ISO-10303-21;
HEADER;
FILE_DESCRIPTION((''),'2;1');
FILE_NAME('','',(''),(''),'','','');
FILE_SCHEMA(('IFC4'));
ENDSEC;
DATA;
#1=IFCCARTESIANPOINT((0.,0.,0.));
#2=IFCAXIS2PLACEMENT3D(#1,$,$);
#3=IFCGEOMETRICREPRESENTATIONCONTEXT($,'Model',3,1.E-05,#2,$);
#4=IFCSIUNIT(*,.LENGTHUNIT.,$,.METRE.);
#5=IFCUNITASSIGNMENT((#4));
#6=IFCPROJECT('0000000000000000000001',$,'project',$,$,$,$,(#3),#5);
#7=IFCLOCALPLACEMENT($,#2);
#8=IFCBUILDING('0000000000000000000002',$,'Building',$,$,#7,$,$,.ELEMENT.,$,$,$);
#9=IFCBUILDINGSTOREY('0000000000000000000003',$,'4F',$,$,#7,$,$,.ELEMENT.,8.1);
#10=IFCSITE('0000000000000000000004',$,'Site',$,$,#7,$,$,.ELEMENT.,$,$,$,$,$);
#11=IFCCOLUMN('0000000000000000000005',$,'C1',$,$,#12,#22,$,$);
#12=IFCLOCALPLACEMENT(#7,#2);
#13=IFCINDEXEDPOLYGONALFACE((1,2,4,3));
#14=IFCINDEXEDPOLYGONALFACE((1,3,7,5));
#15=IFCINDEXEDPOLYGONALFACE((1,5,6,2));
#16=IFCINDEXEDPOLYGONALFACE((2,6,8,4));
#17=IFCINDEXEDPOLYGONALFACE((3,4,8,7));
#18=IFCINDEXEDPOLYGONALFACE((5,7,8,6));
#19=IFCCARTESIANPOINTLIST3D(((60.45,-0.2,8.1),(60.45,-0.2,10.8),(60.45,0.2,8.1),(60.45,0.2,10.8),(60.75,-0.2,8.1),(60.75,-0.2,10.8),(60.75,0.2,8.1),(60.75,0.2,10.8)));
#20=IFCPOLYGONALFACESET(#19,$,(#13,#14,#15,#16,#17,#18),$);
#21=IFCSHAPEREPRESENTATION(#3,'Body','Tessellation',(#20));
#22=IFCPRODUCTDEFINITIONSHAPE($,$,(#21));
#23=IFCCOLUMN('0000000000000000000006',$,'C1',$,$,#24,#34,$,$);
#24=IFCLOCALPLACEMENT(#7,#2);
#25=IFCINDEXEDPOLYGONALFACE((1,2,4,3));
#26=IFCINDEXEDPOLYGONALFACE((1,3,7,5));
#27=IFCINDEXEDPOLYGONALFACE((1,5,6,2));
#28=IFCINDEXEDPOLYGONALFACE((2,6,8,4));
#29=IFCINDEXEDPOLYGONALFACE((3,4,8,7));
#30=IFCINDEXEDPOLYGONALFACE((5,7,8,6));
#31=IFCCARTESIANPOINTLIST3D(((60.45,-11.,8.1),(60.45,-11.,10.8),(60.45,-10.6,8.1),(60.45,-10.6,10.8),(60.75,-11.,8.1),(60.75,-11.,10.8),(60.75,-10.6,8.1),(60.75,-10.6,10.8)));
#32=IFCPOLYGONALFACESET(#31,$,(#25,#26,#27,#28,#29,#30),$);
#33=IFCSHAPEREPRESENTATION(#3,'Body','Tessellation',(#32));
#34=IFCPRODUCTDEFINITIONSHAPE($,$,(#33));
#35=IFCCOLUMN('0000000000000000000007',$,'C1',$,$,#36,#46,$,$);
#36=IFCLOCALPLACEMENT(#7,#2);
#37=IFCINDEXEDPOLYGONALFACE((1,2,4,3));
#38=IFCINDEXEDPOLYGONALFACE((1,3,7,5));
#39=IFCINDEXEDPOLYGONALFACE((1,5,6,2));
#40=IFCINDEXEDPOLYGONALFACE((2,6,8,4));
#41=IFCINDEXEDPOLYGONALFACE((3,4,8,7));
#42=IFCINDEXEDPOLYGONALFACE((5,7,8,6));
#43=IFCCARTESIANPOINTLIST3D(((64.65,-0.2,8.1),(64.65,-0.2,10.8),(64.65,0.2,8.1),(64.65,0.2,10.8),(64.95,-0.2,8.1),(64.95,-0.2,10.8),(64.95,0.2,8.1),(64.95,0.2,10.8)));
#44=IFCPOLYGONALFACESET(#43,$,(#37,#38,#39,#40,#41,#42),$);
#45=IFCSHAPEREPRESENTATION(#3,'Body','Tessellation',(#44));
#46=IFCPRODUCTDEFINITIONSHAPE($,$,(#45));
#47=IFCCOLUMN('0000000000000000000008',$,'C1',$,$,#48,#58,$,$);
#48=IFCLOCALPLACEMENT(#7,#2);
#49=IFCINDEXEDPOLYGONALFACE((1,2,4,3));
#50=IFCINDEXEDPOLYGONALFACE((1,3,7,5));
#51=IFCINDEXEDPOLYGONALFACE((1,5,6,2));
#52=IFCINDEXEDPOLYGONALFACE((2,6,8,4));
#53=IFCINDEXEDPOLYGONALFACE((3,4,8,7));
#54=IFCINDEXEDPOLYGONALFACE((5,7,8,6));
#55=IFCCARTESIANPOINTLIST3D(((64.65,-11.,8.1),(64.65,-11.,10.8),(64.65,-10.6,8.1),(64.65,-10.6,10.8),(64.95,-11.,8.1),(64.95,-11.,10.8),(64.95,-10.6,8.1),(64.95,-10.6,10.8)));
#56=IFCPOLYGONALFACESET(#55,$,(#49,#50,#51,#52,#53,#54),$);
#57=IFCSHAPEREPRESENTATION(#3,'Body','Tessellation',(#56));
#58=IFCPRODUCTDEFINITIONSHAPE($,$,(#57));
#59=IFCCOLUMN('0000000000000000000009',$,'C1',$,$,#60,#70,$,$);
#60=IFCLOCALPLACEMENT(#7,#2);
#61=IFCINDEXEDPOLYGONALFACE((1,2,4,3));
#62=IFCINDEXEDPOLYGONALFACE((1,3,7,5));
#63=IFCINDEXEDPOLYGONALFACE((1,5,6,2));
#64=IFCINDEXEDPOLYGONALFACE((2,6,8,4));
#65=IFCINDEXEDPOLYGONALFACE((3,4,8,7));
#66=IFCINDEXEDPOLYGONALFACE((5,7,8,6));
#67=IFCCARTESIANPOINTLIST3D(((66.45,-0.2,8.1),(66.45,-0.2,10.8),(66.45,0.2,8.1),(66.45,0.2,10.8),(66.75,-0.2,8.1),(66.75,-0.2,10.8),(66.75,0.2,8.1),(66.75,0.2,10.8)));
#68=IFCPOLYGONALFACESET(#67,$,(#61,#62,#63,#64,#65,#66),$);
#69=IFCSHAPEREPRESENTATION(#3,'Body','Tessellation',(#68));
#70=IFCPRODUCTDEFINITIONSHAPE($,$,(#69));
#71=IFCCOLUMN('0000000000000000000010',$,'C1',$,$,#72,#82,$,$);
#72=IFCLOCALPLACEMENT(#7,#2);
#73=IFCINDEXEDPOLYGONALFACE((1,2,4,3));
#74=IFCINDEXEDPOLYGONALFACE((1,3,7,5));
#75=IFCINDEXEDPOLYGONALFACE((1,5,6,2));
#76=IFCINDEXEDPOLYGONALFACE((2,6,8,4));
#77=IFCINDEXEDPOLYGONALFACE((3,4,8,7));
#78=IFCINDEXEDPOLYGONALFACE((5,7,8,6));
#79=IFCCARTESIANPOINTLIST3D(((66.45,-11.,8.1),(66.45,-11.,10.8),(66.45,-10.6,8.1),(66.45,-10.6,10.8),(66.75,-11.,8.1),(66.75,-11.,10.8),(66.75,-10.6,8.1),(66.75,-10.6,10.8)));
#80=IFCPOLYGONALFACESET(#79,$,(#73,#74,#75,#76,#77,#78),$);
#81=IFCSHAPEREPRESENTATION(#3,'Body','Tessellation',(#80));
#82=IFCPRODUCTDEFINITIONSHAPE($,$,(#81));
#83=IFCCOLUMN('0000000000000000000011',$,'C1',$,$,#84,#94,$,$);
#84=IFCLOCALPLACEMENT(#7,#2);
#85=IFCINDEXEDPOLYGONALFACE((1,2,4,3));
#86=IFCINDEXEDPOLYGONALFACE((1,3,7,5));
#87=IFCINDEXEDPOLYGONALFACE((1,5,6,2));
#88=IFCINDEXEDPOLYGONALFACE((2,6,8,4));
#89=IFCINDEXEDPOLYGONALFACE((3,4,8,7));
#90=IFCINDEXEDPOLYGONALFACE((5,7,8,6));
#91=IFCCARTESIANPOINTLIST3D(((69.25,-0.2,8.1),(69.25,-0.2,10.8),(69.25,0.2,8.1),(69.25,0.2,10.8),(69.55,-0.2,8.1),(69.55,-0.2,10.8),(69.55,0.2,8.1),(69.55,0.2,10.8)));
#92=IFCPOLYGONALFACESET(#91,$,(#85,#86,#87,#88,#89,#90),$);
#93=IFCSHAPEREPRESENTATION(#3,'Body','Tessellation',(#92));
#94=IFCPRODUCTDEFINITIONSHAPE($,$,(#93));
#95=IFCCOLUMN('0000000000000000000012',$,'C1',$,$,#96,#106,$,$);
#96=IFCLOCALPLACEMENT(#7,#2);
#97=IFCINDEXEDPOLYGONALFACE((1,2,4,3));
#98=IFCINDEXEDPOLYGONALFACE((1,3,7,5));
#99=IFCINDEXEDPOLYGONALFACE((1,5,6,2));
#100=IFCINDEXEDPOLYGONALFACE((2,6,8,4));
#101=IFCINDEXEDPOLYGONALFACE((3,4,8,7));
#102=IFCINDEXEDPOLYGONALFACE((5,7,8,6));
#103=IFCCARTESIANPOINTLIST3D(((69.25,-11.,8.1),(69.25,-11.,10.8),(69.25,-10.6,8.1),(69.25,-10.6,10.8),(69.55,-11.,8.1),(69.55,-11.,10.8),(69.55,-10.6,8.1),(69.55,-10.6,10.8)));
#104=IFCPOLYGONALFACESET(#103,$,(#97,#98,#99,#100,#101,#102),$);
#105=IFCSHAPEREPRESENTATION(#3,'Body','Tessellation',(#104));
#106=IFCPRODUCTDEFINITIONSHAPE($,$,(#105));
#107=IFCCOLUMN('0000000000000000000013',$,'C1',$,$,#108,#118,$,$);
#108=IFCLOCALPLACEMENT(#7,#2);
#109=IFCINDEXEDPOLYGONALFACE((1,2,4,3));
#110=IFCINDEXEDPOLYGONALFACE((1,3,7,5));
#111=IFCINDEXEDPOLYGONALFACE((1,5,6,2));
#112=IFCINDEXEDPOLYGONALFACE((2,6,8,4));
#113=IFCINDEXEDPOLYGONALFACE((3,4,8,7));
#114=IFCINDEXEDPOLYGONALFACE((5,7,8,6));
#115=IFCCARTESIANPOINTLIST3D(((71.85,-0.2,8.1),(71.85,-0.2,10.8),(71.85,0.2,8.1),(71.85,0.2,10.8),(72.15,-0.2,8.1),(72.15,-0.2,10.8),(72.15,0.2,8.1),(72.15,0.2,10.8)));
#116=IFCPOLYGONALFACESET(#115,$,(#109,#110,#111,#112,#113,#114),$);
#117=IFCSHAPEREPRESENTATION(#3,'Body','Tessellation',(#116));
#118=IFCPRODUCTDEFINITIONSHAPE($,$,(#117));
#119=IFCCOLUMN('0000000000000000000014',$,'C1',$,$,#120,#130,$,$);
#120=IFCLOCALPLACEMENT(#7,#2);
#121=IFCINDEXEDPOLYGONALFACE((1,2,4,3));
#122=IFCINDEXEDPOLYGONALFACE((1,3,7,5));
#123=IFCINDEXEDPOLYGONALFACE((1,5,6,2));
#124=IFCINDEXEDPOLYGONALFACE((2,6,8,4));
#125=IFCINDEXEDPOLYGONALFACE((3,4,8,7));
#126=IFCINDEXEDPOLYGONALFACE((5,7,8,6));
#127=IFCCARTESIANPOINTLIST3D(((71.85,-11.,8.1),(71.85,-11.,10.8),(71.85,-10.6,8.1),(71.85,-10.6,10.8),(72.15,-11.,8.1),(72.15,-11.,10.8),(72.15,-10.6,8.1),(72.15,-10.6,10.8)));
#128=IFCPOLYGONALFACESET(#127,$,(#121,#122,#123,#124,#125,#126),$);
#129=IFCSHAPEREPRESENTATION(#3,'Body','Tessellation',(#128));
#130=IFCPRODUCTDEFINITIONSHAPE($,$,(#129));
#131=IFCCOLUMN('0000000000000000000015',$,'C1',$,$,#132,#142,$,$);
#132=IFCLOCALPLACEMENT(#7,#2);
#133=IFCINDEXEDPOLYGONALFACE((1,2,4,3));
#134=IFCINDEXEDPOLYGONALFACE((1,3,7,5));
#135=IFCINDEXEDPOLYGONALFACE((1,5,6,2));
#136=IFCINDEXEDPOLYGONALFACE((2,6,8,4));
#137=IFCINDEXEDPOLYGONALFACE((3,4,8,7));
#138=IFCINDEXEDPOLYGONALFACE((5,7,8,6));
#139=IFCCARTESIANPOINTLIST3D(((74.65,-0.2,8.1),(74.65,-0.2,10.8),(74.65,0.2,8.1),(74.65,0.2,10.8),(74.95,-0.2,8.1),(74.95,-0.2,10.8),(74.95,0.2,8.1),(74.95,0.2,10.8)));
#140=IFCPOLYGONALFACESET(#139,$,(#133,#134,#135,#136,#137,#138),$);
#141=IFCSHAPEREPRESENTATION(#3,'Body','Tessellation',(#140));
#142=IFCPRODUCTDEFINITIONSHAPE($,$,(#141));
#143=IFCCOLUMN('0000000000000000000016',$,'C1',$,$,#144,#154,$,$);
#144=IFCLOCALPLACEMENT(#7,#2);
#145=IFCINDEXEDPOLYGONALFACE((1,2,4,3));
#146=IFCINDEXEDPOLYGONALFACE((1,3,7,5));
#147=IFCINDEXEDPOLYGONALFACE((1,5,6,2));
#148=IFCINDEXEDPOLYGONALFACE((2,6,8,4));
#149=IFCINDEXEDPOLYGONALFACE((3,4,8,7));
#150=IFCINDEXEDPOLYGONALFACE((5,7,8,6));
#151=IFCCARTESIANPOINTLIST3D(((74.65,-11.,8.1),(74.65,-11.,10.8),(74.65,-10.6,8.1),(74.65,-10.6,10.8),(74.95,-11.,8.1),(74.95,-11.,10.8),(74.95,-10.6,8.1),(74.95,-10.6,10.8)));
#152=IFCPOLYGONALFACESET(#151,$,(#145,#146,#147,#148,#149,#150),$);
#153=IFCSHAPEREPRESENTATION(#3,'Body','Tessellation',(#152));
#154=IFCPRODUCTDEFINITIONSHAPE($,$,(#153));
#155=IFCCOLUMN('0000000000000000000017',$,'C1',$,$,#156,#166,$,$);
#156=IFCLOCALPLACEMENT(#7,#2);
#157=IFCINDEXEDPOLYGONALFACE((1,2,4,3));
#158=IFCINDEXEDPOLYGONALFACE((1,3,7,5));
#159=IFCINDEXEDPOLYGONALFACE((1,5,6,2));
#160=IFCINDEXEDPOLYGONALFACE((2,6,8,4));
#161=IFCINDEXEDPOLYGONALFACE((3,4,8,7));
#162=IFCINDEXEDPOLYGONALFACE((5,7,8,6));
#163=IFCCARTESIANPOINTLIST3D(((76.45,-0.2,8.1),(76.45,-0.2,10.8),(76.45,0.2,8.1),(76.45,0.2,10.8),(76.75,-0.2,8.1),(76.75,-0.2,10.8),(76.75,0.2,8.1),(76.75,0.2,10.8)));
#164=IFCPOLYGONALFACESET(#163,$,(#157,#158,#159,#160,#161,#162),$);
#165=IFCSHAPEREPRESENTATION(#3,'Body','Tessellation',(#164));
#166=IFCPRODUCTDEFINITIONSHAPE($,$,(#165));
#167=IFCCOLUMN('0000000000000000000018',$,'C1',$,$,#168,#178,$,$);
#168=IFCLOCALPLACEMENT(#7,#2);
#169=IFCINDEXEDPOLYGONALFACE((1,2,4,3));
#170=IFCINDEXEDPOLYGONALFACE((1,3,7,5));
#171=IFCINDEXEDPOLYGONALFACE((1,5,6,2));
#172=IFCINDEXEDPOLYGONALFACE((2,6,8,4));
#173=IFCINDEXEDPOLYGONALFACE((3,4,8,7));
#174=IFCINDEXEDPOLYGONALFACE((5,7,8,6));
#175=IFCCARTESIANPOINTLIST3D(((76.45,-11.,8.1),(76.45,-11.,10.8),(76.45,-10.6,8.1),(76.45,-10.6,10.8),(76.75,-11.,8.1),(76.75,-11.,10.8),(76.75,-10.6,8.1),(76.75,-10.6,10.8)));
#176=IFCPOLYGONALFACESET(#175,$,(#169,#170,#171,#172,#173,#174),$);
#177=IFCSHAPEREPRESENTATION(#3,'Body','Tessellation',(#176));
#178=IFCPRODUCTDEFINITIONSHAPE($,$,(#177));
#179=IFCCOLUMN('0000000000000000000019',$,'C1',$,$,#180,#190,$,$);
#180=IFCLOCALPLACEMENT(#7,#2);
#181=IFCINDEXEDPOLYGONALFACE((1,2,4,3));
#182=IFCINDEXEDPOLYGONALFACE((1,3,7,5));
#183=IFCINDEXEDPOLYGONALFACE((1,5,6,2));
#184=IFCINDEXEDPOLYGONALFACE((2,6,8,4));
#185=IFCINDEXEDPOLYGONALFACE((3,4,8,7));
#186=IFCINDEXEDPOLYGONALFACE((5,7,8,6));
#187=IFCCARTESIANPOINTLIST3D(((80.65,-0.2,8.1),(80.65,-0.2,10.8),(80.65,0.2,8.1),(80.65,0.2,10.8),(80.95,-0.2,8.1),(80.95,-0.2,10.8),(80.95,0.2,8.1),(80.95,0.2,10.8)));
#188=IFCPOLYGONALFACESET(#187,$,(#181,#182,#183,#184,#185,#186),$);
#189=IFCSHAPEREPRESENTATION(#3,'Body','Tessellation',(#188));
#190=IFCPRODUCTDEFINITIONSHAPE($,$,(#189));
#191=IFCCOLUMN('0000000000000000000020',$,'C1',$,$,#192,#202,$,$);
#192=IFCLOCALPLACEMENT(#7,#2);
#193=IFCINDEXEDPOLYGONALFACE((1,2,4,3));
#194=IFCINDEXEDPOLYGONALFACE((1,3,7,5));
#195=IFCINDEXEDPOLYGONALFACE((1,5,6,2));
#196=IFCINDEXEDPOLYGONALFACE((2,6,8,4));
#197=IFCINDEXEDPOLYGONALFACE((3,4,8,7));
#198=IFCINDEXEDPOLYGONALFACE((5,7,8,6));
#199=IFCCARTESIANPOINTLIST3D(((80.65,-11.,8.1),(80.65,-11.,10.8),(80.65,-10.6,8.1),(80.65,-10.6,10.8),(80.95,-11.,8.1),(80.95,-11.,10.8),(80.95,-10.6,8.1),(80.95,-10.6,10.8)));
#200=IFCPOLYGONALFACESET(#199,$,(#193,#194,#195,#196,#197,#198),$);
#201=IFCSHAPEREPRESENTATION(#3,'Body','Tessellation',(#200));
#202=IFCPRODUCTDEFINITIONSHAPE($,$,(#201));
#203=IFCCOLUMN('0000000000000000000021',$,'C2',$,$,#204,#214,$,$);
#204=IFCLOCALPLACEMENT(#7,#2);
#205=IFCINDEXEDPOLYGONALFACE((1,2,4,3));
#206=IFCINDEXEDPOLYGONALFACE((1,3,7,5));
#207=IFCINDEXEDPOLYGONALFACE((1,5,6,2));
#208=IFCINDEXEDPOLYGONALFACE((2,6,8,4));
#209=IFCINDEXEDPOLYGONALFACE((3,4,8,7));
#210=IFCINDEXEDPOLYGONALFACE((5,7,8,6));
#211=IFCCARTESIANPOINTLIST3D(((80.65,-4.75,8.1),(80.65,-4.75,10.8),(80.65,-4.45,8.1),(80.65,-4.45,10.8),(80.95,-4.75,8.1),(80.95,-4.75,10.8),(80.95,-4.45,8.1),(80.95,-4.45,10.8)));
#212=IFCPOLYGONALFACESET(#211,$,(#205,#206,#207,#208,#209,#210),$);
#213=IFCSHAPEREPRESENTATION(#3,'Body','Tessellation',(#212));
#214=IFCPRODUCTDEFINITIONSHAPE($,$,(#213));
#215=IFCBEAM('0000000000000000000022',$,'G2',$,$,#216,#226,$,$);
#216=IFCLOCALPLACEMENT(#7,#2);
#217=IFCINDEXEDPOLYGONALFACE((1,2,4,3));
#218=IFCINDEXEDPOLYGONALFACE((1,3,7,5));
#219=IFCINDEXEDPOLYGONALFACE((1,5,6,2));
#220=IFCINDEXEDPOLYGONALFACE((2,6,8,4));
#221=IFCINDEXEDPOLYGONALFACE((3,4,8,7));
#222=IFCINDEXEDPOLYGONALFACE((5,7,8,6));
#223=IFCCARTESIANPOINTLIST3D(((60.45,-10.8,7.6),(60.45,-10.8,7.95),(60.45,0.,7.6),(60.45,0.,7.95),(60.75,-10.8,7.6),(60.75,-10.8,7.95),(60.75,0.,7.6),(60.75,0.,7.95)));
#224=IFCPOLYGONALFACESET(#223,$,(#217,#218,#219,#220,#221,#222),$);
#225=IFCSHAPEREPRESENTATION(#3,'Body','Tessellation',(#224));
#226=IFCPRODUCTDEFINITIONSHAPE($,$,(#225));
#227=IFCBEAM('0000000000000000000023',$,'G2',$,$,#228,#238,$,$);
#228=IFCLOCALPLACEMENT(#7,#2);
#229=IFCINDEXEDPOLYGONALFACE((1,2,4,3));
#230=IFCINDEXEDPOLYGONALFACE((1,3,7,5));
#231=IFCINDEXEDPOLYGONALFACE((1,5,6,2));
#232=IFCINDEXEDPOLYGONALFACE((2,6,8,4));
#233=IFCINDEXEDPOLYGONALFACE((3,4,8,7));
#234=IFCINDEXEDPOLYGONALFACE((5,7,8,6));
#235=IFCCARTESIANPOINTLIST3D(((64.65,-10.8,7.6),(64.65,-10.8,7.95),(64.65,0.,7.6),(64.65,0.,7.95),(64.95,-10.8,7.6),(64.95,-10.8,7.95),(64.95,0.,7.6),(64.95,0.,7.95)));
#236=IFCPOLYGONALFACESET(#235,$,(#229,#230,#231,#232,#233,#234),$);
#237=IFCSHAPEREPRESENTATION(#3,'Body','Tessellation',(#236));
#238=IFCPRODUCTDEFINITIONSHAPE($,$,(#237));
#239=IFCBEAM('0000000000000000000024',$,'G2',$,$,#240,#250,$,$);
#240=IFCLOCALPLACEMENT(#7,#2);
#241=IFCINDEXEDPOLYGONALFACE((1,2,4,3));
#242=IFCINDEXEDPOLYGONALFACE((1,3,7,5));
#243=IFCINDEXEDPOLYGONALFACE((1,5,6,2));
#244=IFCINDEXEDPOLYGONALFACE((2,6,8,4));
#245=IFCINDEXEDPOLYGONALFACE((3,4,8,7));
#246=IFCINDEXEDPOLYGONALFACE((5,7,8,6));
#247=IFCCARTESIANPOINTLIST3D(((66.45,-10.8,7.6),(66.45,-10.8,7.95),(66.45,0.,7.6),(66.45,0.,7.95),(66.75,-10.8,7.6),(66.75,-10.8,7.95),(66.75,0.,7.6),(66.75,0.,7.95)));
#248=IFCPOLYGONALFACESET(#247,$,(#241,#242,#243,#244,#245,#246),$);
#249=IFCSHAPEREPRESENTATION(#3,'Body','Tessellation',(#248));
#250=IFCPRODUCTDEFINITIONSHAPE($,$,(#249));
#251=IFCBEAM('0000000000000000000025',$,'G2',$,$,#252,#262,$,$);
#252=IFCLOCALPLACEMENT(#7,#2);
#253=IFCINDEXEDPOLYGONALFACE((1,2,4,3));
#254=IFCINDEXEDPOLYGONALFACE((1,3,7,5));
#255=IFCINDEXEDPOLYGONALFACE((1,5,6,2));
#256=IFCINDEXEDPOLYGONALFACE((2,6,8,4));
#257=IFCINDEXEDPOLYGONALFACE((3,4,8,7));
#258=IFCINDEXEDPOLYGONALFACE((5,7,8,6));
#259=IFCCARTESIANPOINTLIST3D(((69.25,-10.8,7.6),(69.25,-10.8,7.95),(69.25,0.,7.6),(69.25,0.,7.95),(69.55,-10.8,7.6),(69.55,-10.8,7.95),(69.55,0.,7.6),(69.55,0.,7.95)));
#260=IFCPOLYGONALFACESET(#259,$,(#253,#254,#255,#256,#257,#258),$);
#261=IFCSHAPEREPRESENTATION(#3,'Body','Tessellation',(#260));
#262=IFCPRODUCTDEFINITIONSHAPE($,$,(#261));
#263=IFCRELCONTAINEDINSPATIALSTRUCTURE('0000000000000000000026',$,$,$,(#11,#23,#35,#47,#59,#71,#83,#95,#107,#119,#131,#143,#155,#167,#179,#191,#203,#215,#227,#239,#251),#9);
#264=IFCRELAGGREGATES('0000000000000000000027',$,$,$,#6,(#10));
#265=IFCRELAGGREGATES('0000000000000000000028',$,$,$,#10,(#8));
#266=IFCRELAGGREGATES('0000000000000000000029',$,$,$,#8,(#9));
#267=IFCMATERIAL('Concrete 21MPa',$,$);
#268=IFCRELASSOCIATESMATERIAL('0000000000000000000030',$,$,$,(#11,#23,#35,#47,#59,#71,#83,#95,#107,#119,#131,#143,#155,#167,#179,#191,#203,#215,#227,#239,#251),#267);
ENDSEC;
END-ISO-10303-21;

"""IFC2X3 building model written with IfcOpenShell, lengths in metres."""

from ifc_helpers import new_model, si_unit, frame, origin, origin_2d, place, context, project, spatial, rectangle, extrude, material, element, save


model = new_model("IFC2X3")

# Units and contexts
model_context = context("Model", 3, precision=1e-05, world=origin())
ifc_project = project(units=[si_unit("LENGTHUNIT", "METRE")], contexts=[model_context])

# Site, building, storey
placement = place(None, origin())
site = spatial("IfcSite", under=ifc_project, at=placement, Name="Site", CompositionType="ELEMENT")
building = spatial("IfcBuilding", under=site, at=placement, Name="Building", CompositionType="ELEMENT")
storey = spatial("IfcBuildingStorey", under=building, at=placement, Name="4F", CompositionType="ELEMENT", Elevation=8.1)

# Columns
ifc_material = material(Name="Concrete 21MPa")
for number, where, name in (
    (1, (60.6, 0.0, 8.1), "C1"),
    (2, (60.6, -10.8, 8.1), "C1"),
    (3, (64.8, 0.0, 8.1), "C1"),
    (4, (64.8, -10.8, 8.1), "C1"),
    (5, (66.6, 0.0, 8.1), "C1"),
    (6, (66.6, -10.8, 8.1), "C1"),
    (7, (69.4, 0.0, 8.1), "C1"),
    (8, (69.4, -10.8, 8.1), "C1"),
    (9, (72.0, 0.0, 8.1), "C1"),
    (10, (72.0, -10.8, 8.1), "C1"),
    (11, (74.8, 0.0, 8.1), "C1"),
    (12, (74.8, -10.8, 8.1), "C1"),
    (13, (76.6, 0.0, 8.1), "C1"),
    (14, (76.6, -10.8, 8.1), "C1"),
    (15, (80.8, 0.0, 8.1), "C1"),
    (16, (80.8, -10.8, 8.1), "C1"),
):
    element("IfcColumn", number, at=place(None, frame(where)), inside=storey, material=ifc_material, Name=name, context=model_context, shape_type="SweptSolid", body=[
        extrude(rectangle(XDim=0.3, YDim=0.4, at=origin_2d()), origin(), (0.0, 0.0, 1.0), 2.7),
    ])
column_placement = place(None, frame((80.8, -4.6, 8.1)))
element("IfcColumn", 17, at=column_placement, inside=storey, material=ifc_material, Name="C2", context=model_context, shape_type="SweptSolid", body=[
    extrude(rectangle(XDim=0.3, YDim=0.3, at=origin_2d()), origin(), (0.0, 0.0, 1.0), 2.7),
])

# Beams
for number, where, name in (
    (18, (60.6, -5.4, 7.6), "G2"),
    (19, (64.8, -5.4, 7.6), "G2"),
    (20, (66.6, -5.4, 7.6), "G2"),
    (21, (69.4, -5.4, 7.6), "G2"),
):
    element("IfcBeam", number, at=place(None, frame(where)), inside=storey, material=ifc_material, Name=name, context=model_context, shape_type="SweptSolid", body=[
        extrude(rectangle(XDim=0.3, YDim=10.8, at=origin_2d()), origin(), (0.0, 0.0, 1.0), 0.35),
    ])

save(model, "model.ifc")
